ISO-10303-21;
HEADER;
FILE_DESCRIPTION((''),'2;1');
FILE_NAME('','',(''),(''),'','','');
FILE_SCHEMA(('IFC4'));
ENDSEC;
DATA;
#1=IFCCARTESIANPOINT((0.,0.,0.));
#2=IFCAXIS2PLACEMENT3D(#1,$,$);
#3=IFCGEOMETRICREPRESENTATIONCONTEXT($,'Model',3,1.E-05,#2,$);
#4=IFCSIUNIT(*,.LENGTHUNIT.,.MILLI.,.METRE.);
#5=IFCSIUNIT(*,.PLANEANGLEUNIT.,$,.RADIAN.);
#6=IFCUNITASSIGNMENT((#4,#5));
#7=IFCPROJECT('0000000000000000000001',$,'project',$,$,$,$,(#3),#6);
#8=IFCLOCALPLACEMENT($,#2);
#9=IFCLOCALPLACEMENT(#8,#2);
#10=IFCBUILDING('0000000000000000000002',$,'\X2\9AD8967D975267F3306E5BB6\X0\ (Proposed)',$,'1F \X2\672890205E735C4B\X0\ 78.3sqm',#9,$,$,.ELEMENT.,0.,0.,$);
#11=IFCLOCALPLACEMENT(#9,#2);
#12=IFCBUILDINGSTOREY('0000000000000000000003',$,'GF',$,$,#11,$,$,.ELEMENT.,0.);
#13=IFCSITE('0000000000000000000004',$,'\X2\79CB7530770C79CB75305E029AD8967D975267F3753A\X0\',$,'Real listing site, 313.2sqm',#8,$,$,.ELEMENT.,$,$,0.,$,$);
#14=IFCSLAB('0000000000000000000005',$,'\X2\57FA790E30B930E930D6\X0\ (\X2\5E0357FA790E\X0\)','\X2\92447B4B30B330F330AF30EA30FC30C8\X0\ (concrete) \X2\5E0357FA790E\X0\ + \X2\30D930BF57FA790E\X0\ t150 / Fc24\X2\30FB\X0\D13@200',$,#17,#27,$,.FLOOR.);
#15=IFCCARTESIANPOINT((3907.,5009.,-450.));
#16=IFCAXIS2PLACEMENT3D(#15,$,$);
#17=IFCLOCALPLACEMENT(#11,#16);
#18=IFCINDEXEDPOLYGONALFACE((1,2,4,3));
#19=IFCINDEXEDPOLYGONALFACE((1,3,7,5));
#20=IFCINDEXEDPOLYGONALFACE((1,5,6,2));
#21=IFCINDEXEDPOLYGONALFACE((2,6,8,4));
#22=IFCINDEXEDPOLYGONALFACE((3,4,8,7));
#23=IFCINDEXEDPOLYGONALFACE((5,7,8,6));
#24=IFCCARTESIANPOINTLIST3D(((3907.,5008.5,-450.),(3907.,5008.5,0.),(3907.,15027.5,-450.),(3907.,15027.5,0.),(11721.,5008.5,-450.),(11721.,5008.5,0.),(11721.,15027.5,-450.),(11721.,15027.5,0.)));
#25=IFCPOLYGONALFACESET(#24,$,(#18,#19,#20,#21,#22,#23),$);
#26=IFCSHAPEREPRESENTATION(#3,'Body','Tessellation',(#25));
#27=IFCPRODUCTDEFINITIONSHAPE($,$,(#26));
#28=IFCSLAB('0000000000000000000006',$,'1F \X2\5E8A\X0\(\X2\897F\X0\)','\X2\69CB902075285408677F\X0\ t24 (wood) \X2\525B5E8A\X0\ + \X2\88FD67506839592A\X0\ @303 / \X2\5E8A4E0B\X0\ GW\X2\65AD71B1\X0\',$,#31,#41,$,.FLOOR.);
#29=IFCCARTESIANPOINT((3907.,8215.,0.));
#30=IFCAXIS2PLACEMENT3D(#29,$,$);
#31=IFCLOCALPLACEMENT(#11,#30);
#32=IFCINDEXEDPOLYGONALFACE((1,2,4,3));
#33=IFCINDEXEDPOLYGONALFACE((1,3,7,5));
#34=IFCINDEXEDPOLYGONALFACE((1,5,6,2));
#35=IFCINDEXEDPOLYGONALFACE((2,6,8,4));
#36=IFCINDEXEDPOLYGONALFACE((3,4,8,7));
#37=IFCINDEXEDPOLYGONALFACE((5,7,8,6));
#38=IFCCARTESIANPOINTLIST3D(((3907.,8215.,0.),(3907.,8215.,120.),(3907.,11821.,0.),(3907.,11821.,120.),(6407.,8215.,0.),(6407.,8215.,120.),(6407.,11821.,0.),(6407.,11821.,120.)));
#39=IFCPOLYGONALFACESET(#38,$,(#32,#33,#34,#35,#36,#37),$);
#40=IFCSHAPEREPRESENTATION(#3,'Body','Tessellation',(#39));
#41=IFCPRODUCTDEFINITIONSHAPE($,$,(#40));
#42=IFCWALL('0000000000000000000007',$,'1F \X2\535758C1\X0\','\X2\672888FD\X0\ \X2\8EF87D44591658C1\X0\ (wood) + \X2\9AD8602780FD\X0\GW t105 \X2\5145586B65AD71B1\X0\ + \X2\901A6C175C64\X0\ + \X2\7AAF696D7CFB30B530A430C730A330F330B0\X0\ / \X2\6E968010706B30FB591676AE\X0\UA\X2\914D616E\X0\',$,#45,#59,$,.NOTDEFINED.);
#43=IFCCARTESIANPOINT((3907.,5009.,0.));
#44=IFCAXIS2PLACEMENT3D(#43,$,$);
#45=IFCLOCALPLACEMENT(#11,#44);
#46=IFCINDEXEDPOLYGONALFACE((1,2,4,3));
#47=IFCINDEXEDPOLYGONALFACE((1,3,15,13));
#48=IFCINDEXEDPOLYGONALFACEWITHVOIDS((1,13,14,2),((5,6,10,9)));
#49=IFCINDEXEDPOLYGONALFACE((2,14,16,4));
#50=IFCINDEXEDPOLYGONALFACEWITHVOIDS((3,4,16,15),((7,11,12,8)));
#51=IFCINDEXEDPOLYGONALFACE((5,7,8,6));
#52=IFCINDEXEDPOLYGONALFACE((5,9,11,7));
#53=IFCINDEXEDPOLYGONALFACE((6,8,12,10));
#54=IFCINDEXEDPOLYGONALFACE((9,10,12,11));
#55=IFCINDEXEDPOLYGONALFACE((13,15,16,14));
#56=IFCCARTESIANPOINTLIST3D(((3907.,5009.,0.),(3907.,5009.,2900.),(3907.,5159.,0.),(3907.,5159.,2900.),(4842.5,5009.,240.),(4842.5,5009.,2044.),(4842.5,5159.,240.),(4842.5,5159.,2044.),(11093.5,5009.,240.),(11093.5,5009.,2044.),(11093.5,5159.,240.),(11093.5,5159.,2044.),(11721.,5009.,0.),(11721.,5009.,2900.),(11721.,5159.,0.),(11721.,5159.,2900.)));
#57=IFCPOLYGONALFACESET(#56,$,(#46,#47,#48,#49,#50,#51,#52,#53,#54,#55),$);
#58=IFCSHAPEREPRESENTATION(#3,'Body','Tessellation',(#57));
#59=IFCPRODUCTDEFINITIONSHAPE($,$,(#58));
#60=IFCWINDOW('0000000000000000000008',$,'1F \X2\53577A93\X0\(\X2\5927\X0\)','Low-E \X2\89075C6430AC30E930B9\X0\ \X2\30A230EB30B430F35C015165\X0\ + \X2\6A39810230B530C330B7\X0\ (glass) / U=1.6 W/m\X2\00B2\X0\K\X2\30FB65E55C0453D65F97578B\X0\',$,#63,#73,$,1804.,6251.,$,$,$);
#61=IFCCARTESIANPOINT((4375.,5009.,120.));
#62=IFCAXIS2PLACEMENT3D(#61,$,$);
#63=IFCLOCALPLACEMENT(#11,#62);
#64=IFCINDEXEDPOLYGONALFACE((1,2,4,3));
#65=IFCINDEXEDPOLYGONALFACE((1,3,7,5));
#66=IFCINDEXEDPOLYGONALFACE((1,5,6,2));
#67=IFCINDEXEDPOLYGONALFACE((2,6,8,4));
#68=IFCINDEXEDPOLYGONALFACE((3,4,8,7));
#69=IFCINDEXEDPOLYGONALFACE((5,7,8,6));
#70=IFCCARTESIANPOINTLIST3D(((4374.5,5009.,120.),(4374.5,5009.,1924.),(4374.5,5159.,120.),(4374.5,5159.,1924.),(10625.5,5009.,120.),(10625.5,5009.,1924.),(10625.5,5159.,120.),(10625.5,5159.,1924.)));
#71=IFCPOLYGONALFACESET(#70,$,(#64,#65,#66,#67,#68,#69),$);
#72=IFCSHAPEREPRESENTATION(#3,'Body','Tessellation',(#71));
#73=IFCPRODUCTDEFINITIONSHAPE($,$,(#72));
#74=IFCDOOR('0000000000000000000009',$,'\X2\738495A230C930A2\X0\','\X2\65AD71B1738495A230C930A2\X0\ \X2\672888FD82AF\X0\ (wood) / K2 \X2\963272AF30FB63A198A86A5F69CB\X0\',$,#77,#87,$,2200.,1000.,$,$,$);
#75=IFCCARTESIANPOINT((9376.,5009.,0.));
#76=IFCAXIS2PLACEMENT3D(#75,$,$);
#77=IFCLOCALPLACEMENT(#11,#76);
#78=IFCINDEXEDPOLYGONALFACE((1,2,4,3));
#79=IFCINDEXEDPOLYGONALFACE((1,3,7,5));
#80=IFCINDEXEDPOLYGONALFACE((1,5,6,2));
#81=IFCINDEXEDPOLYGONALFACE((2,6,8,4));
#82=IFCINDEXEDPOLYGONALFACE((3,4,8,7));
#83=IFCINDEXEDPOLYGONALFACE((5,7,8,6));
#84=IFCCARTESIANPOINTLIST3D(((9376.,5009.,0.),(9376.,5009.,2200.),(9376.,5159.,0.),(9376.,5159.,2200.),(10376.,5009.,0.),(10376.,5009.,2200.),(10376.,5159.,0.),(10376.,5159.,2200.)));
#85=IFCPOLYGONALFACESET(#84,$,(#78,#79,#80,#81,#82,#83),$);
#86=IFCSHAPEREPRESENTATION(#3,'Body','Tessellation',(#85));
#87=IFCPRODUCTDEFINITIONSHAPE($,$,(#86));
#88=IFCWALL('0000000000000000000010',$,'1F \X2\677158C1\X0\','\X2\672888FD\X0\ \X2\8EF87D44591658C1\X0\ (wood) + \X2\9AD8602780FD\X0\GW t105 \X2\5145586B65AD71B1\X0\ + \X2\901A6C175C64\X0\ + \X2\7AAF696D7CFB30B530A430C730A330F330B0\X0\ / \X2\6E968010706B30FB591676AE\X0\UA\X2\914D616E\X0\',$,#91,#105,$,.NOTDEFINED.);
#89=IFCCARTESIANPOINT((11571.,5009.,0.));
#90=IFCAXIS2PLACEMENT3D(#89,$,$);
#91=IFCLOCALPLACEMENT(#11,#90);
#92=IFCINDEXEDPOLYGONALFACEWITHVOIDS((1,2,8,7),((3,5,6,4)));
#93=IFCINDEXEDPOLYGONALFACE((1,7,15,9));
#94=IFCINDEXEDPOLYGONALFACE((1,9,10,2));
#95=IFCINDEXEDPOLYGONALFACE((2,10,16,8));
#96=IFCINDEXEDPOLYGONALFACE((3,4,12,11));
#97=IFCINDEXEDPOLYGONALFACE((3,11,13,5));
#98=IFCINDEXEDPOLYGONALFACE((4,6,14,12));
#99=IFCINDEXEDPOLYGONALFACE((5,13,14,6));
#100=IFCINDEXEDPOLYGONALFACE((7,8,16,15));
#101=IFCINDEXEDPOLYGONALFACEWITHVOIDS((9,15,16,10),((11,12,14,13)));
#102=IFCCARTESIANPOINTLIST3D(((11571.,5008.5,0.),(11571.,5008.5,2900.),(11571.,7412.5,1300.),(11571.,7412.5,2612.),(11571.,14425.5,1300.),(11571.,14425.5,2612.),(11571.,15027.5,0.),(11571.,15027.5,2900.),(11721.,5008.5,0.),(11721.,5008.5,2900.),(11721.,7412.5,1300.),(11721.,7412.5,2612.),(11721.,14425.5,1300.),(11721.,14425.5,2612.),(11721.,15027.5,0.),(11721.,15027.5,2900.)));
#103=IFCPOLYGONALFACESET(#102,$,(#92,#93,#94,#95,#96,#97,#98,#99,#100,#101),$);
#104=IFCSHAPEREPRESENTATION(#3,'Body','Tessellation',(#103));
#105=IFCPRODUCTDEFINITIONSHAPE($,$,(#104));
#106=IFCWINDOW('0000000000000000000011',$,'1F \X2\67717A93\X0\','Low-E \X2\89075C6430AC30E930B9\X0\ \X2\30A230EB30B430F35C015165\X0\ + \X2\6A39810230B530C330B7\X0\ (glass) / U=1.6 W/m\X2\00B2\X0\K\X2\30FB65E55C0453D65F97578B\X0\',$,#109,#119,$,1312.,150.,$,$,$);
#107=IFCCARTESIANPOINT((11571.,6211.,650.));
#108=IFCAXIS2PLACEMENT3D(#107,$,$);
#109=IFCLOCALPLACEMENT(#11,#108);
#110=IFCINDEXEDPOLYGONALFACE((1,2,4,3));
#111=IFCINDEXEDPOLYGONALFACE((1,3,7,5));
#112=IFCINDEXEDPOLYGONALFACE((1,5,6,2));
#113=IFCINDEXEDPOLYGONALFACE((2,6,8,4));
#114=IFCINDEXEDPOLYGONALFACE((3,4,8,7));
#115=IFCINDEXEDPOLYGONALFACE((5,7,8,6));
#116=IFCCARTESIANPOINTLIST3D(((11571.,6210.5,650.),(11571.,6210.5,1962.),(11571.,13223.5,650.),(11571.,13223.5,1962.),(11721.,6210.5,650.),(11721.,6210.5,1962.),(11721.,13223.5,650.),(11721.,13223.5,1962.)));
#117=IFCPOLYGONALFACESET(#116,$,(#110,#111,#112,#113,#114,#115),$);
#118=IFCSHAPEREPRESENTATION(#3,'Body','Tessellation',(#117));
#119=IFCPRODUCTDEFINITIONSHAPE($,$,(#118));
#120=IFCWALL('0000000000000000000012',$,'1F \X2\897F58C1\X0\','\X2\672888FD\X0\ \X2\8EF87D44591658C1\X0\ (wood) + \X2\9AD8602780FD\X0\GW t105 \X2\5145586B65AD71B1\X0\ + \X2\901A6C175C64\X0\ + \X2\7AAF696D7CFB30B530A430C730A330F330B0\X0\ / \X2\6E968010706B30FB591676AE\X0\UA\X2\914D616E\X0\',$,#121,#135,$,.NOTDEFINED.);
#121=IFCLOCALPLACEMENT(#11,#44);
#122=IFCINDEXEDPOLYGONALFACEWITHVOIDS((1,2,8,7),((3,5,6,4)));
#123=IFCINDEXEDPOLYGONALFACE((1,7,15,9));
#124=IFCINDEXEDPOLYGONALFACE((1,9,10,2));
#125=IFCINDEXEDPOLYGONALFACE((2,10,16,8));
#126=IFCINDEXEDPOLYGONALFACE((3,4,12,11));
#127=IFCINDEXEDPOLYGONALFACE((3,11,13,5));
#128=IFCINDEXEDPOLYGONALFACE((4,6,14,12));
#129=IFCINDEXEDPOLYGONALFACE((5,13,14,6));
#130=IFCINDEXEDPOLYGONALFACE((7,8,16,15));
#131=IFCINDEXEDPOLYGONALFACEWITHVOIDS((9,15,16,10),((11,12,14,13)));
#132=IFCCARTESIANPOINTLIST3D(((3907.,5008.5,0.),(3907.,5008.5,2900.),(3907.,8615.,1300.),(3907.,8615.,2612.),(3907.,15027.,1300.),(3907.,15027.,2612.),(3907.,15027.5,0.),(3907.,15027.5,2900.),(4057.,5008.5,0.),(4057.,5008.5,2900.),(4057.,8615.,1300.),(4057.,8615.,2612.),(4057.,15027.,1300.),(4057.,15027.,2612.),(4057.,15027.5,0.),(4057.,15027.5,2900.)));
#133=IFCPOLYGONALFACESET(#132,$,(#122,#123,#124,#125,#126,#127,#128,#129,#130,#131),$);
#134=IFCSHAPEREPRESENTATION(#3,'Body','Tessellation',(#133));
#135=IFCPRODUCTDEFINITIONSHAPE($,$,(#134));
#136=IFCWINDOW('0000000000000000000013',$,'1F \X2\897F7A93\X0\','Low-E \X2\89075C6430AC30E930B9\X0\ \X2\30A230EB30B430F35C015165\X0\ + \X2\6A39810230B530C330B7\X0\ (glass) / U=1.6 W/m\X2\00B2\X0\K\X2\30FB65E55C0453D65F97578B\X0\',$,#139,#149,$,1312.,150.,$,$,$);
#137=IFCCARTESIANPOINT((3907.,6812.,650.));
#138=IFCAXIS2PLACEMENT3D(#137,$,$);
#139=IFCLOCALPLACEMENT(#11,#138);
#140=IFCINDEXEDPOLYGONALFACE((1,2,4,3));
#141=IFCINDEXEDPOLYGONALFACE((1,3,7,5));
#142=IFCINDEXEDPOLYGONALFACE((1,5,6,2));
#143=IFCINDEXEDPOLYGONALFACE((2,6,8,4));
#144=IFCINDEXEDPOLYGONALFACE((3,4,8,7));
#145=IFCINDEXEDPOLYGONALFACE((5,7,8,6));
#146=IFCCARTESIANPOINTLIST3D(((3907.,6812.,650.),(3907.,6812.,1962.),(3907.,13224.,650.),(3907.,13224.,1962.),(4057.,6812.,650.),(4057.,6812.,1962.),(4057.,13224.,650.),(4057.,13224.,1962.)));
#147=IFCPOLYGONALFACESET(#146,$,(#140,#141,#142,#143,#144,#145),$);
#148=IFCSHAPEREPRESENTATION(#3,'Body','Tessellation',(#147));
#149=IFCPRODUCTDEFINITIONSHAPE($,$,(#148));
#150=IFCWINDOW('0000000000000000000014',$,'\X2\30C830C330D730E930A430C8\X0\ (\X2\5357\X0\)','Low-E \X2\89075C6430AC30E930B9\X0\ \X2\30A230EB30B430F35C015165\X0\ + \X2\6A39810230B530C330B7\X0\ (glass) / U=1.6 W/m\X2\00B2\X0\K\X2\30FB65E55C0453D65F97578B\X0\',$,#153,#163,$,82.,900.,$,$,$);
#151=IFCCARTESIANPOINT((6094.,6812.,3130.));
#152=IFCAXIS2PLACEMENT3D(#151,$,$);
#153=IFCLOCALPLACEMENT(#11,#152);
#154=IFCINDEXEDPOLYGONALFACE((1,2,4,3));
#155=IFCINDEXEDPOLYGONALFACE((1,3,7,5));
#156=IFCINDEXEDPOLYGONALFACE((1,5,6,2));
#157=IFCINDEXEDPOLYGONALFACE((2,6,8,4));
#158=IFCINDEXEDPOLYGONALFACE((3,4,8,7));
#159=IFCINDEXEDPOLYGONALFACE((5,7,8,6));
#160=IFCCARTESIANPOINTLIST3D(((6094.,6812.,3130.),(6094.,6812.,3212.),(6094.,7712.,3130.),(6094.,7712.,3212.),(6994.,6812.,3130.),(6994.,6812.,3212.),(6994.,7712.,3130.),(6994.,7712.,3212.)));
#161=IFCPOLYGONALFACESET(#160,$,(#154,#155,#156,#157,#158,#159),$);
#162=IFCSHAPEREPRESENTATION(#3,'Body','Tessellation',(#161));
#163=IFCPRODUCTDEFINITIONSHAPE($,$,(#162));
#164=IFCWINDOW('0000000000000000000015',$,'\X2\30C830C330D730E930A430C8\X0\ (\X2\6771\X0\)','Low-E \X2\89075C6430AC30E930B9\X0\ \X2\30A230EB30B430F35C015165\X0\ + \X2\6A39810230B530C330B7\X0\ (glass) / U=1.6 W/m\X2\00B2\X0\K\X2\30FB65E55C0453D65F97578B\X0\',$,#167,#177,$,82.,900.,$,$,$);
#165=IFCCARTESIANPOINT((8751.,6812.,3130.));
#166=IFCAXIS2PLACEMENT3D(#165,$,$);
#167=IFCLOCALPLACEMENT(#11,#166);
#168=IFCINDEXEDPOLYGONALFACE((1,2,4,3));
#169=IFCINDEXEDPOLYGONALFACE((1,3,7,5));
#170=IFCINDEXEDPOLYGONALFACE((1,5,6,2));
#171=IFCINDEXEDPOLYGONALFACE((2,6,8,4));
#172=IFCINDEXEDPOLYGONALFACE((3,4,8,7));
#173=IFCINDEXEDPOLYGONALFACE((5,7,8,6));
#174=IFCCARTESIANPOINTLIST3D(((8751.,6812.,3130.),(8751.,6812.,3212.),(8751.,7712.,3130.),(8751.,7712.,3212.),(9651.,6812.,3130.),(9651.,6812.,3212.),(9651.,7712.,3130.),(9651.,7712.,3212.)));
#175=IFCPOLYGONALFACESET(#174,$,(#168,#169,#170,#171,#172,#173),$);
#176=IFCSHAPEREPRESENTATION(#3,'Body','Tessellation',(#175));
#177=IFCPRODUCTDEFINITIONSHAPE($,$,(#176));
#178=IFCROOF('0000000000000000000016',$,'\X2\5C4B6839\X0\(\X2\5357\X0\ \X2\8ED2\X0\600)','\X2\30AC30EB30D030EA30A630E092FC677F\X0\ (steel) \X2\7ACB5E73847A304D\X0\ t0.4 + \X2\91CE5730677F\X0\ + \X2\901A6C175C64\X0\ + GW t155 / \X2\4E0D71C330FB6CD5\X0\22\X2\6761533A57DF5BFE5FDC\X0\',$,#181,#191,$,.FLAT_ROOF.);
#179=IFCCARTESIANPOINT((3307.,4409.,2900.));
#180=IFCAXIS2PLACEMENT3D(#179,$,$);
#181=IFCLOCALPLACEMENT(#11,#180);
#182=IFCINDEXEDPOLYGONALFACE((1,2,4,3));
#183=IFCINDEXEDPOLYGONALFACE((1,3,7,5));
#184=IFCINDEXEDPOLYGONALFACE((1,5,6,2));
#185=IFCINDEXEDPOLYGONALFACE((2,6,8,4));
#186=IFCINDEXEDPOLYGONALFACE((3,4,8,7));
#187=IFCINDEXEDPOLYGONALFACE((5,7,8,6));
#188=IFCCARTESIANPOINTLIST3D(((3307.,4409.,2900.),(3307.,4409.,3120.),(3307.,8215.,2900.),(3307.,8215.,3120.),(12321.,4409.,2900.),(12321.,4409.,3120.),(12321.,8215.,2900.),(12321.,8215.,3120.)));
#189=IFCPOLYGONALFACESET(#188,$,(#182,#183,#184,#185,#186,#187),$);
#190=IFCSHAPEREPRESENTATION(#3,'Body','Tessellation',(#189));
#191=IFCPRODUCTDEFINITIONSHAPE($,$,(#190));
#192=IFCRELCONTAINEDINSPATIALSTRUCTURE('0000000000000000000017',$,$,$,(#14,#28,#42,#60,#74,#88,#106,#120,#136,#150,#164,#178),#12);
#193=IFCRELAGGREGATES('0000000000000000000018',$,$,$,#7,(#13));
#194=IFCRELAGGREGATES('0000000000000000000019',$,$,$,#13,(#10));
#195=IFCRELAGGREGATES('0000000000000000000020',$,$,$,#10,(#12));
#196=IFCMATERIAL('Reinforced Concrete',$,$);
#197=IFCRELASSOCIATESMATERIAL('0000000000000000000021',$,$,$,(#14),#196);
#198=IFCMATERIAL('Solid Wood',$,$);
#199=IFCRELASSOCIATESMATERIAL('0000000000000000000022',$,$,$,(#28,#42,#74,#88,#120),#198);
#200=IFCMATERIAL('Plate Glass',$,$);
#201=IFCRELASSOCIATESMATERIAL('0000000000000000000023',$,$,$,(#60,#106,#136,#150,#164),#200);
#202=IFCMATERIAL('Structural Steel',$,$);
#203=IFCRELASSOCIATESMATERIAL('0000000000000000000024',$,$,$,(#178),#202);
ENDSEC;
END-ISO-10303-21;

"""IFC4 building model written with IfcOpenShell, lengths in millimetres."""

from ifc_helpers import new_model, si_unit, frame, frame_2d, origin, place, context, project, spatial, rectangle, extrude, material, element, fill, save


model = new_model("IFC4")

# Units and contexts
model_context = context("Model", 3, precision=1e-05, world=origin())
ifc_project = project(units=[si_unit("LENGTHUNIT", "METRE", prefix="MILLI"), si_unit("PLANEANGLEUNIT", "RADIAN")], contexts=[model_context])

# Site, building, storey
site_placement = place(None, origin())
site = spatial("IfcSite", under=ifc_project, at=site_placement, Name="秋田県秋田市高陽青柳町", ObjectType="Real listing site, 313.2sqm", CompositionType="ELEMENT", RefElevation=0.0)
building_placement = place(site_placement, origin())
building = spatial("IfcBuilding", under=site, at=building_placement, Name="高陽青柳の家 (Proposed)", ObjectType="1F 木造平屋 78.3sqm", CompositionType="ELEMENT", ElevationOfRefHeight=0.0, ElevationOfTerrain=0.0)
storey_placement = place(building_placement, origin())
storey = spatial("IfcBuildingStorey", under=building, at=storey_placement, Name="GF", CompositionType="ELEMENT", Elevation=0.0)

# Slabs
ifc_material_1 = material(Name="Reinforced Concrete")
slab_1_placement = place(storey_placement, frame((3907.0, 5009.0, -450.0)))
element("IfcSlab", 1, at=slab_1_placement, inside=storey, material=ifc_material_1, Name="基礎スラブ (布基礎)", Description="鉄筋コンクリート (concrete) 布基礎 + ベタ基礎 t150 / Fc24・D13@200", PredefinedType="FLOOR", context=model_context, shape_type="SweptSolid", body=[
    extrude(rectangle(XDim=7814.0, YDim=10019.0, at=frame_2d((3907.0, 5009.0))), frame((3907.0, 5009.0, -450.0)), (0.0, 0.0, 1.0), 450.0),
])
ifc_material_2 = material(Name="Solid Wood")
slab_2_placement = place(storey_placement, frame((3907.0, 8215.0, 0.0)))
element("IfcSlab", 2, at=slab_2_placement, inside=storey, material=ifc_material_2, Name="1F 床(西)", Description="構造用合板 t24 (wood) 剛床 + 製材根太 @303 / 床下 GW断熱", PredefinedType="FLOOR", context=model_context, shape_type="SweptSolid", body=[
    extrude(rectangle(XDim=2500.0, YDim=3606.0, at=frame_2d((1250.0, 1803.0))), frame((3907.0, 8215.0, 0.0)), (0.0, 0.0, 1.0), 120.0),
])

# Wall, openings, window, door
wall_1_placement = place(storey_placement, frame((3907.0, 5009.0, 0.0)))
wall_1 = element("IfcWall", 3, at=wall_1_placement, inside=storey, material=ifc_material_2, Name="1F 南壁", Description="木製 軸組外壁 (wood) + 高性能GW t105 充填断熱 + 通気層 + 窯業系サイディング / 準耐火・外皮UA配慮", PredefinedType="NOTDEFINED", context=model_context, shape_type="SweptSolid", body=[
    extrude(rectangle(XDim=7814.0, YDim=150.0, at=frame_2d((3907.0, 75.0))), frame((3907.0, 5009.0, 0.0)), (0.0, 0.0, 1.0), 2900.0),
])
opening_1_placement = place(storey_placement, frame((4375.0, 5009.0, 120.0)))
opening_1 = element("IfcOpeningElement", 4, at=opening_1_placement, cuts=wall_1, PredefinedType="NOTDEFINED", context=model_context, shape_type="SweptSolid", body=[
    extrude(rectangle(XDim=6251.0, YDim=150.0, at=frame_2d((3125.0, 75.0))), frame((4375.0, 5009.0, 120.0)), (0.0, 0.0, 1.0), 1804.0),
])
opening_2_placement = place(storey_placement, frame((9376.0, 5009.0, 0.0)))
opening_2 = element("IfcOpeningElement", 5, at=opening_2_placement, cuts=wall_1, PredefinedType="NOTDEFINED", context=model_context, shape_type="SweptSolid", body=[
    extrude(rectangle(XDim=1000.0, YDim=150.0, at=frame_2d((500.0, 75.0))), frame((9376.0, 5009.0, 0.0)), (0.0, 0.0, 1.0), 2200.0),
])
ifc_material_3 = material(Name="Plate Glass")
window_1_placement = place(storey_placement, frame((4375.0, 5009.0, 120.0)))
window_1 = element("IfcWindow", 6, at=window_1_placement, inside=storey, material=ifc_material_3, Name="1F 南窓(大)", Description="Low-E 複層ガラス アルゴン封入 + 樹脂サッシ (glass) / U=1.6 W/m²K・日射取得型", OverallHeight=1804.0, OverallWidth=6251.0, context=model_context, shape_type="SweptSolid", body=[
    extrude(rectangle(XDim=6251.0, YDim=150.0, at=frame_2d((3125.0, 75.0))), frame((4375.0, 5009.0, 120.0)), (0.0, 0.0, 1.0), 1804.0),
])
fill(opening_1, window_1)
door_placement = place(storey_placement, frame((9376.0, 5009.0, 0.0)))
door = element("IfcDoor", 7, at=door_placement, inside=storey, material=ifc_material_2, Name="玄関ドア", Description="断熱玄関ドア 木製芯 (wood) / K2 防犯・採風機構", OverallHeight=2200.0, OverallWidth=1000.0, context=model_context, shape_type="SweptSolid", body=[
    extrude(rectangle(XDim=1000.0, YDim=150.0, at=frame_2d((500.0, 75.0))), frame((9376.0, 5009.0, 0.0)), (0.0, 0.0, 1.0), 2200.0),
])
fill(opening_2, door)

# Walls, openings, windows
wall_2_placement = place(storey_placement, frame((11571.0, 5009.0, 0.0)))
wall_2 = element("IfcWall", 8, at=wall_2_placement, inside=storey, material=ifc_material_2, Name="1F 東壁", Description="木製 軸組外壁 (wood) + 高性能GW t105 充填断熱 + 通気層 + 窯業系サイディング / 準耐火・外皮UA配慮", PredefinedType="NOTDEFINED", context=model_context, shape_type="SweptSolid", body=[
    extrude(rectangle(XDim=150.0, YDim=10019.0, at=frame_2d((75.0, 5009.0))), frame((11571.0, 5009.0, 0.0)), (0.0, 0.0, 1.0), 2900.0),
])
opening_3_placement = place(storey_placement, frame((11571.0, 6211.0, 650.0)))
opening_3 = element("IfcOpeningElement", 9, at=opening_3_placement, cuts=wall_2, PredefinedType="NOTDEFINED", context=model_context, shape_type="SweptSolid", body=[
    extrude(rectangle(XDim=150.0, YDim=7013.0, at=frame_2d((75.0, 3506.0))), frame((11571.0, 6211.0, 650.0)), (0.0, 0.0, 1.0), 1312.0),
])
window_2_placement = place(storey_placement, frame((11571.0, 6211.0, 650.0)))
window_2 = element("IfcWindow", 10, at=window_2_placement, inside=storey, material=ifc_material_3, Name="1F 東窓", Description="Low-E 複層ガラス アルゴン封入 + 樹脂サッシ (glass) / U=1.6 W/m²K・日射取得型", OverallHeight=1312.0, OverallWidth=150.0, context=model_context, shape_type="SweptSolid", body=[
    extrude(rectangle(XDim=150.0, YDim=7013.0, at=frame_2d((75.0, 3506.0))), frame((11571.0, 6211.0, 650.0)), (0.0, 0.0, 1.0), 1312.0),
])
fill(opening_3, window_2)
wall_3_placement = place(storey_placement, frame((3907.0, 5009.0, 0.0)))
wall_3 = element("IfcWall", 11, at=wall_3_placement, inside=storey, material=ifc_material_2, Name="1F 西壁", Description="木製 軸組外壁 (wood) + 高性能GW t105 充填断熱 + 通気層 + 窯業系サイディング / 準耐火・外皮UA配慮", PredefinedType="NOTDEFINED", context=model_context, shape_type="SweptSolid", body=[
    extrude(rectangle(XDim=150.0, YDim=10019.0, at=frame_2d((75.0, 5009.0))), frame((3907.0, 5009.0, 0.0)), (0.0, 0.0, 1.0), 2900.0),
])
opening_4_placement = place(storey_placement, frame((3907.0, 6812.0, 650.0)))
opening_4 = element("IfcOpeningElement", 12, at=opening_4_placement, cuts=wall_3, PredefinedType="NOTDEFINED", context=model_context, shape_type="SweptSolid", body=[
    extrude(rectangle(XDim=150.0, YDim=6412.0, at=frame_2d((75.0, 3206.0))), frame((3907.0, 6812.0, 650.0)), (0.0, 0.0, 1.0), 1312.0),
])
window_3_placement = place(storey_placement, frame((3907.0, 6812.0, 650.0)))
window_3 = element("IfcWindow", 13, at=window_3_placement, inside=storey, material=ifc_material_3, Name="1F 西窓", Description="Low-E 複層ガラス アルゴン封入 + 樹脂サッシ (glass) / U=1.6 W/m²K・日射取得型", OverallHeight=1312.0, OverallWidth=150.0, context=model_context, shape_type="SweptSolid", body=[
    extrude(rectangle(XDim=150.0, YDim=6412.0, at=frame_2d((75.0, 3206.0))), frame((3907.0, 6812.0, 650.0)), (0.0, 0.0, 1.0), 1312.0),
])
fill(opening_4, window_3)

# Windows
window_4_placement = place(storey_placement, frame((6094.0, 6812.0, 3130.0)))
element("IfcWindow", 14, at=window_4_placement, inside=storey, material=ifc_material_3, Name="トップライト (南)", Description="Low-E 複層ガラス アルゴン封入 + 樹脂サッシ (glass) / U=1.6 W/m²K・日射取得型", OverallHeight=82.0, OverallWidth=900.0, context=model_context, shape_type="SweptSolid", body=[
    extrude(rectangle(XDim=900.0, YDim=900.0, at=frame_2d((450.0, 450.0))), frame((6094.0, 6812.0, 3130.0)), (0.0, 0.0, 1.0), 82.0),
])
window_5_placement = place(storey_placement, frame((8751.0, 6812.0, 3130.0)))
element("IfcWindow", 15, at=window_5_placement, inside=storey, material=ifc_material_3, Name="トップライト (東)", Description="Low-E 複層ガラス アルゴン封入 + 樹脂サッシ (glass) / U=1.6 W/m²K・日射取得型", OverallHeight=82.0, OverallWidth=900.0, context=model_context, shape_type="SweptSolid", body=[
    extrude(rectangle(XDim=900.0, YDim=900.0, at=frame_2d((450.0, 450.0))), frame((8751.0, 6812.0, 3130.0)), (0.0, 0.0, 1.0), 82.0),
])

# Roof
ifc_material_4 = material(Name="Structural Steel")
roof_placement = place(storey_placement, frame((3307.0, 4409.0, 2900.0)))
element("IfcRoof", 16, at=roof_placement, inside=storey, material=ifc_material_4, Name="屋根(南 軒600)", Description="ガルバリウム鋼板 (steel) 立平葺き t0.4 + 野地板 + 通気層 + GW t155 / 不燃・法22条区域対応", PredefinedType="FLAT_ROOF", context=model_context, shape_type="SweptSolid", body=[
    extrude(rectangle(XDim=9014.0, YDim=3806.0, at=frame_2d((4507.0, 1903.0))), frame((3307.0, 4409.0, 2900.0)), (0.0, 0.0, 1.0), 220.0),
])

save(model, "model.ifc")
